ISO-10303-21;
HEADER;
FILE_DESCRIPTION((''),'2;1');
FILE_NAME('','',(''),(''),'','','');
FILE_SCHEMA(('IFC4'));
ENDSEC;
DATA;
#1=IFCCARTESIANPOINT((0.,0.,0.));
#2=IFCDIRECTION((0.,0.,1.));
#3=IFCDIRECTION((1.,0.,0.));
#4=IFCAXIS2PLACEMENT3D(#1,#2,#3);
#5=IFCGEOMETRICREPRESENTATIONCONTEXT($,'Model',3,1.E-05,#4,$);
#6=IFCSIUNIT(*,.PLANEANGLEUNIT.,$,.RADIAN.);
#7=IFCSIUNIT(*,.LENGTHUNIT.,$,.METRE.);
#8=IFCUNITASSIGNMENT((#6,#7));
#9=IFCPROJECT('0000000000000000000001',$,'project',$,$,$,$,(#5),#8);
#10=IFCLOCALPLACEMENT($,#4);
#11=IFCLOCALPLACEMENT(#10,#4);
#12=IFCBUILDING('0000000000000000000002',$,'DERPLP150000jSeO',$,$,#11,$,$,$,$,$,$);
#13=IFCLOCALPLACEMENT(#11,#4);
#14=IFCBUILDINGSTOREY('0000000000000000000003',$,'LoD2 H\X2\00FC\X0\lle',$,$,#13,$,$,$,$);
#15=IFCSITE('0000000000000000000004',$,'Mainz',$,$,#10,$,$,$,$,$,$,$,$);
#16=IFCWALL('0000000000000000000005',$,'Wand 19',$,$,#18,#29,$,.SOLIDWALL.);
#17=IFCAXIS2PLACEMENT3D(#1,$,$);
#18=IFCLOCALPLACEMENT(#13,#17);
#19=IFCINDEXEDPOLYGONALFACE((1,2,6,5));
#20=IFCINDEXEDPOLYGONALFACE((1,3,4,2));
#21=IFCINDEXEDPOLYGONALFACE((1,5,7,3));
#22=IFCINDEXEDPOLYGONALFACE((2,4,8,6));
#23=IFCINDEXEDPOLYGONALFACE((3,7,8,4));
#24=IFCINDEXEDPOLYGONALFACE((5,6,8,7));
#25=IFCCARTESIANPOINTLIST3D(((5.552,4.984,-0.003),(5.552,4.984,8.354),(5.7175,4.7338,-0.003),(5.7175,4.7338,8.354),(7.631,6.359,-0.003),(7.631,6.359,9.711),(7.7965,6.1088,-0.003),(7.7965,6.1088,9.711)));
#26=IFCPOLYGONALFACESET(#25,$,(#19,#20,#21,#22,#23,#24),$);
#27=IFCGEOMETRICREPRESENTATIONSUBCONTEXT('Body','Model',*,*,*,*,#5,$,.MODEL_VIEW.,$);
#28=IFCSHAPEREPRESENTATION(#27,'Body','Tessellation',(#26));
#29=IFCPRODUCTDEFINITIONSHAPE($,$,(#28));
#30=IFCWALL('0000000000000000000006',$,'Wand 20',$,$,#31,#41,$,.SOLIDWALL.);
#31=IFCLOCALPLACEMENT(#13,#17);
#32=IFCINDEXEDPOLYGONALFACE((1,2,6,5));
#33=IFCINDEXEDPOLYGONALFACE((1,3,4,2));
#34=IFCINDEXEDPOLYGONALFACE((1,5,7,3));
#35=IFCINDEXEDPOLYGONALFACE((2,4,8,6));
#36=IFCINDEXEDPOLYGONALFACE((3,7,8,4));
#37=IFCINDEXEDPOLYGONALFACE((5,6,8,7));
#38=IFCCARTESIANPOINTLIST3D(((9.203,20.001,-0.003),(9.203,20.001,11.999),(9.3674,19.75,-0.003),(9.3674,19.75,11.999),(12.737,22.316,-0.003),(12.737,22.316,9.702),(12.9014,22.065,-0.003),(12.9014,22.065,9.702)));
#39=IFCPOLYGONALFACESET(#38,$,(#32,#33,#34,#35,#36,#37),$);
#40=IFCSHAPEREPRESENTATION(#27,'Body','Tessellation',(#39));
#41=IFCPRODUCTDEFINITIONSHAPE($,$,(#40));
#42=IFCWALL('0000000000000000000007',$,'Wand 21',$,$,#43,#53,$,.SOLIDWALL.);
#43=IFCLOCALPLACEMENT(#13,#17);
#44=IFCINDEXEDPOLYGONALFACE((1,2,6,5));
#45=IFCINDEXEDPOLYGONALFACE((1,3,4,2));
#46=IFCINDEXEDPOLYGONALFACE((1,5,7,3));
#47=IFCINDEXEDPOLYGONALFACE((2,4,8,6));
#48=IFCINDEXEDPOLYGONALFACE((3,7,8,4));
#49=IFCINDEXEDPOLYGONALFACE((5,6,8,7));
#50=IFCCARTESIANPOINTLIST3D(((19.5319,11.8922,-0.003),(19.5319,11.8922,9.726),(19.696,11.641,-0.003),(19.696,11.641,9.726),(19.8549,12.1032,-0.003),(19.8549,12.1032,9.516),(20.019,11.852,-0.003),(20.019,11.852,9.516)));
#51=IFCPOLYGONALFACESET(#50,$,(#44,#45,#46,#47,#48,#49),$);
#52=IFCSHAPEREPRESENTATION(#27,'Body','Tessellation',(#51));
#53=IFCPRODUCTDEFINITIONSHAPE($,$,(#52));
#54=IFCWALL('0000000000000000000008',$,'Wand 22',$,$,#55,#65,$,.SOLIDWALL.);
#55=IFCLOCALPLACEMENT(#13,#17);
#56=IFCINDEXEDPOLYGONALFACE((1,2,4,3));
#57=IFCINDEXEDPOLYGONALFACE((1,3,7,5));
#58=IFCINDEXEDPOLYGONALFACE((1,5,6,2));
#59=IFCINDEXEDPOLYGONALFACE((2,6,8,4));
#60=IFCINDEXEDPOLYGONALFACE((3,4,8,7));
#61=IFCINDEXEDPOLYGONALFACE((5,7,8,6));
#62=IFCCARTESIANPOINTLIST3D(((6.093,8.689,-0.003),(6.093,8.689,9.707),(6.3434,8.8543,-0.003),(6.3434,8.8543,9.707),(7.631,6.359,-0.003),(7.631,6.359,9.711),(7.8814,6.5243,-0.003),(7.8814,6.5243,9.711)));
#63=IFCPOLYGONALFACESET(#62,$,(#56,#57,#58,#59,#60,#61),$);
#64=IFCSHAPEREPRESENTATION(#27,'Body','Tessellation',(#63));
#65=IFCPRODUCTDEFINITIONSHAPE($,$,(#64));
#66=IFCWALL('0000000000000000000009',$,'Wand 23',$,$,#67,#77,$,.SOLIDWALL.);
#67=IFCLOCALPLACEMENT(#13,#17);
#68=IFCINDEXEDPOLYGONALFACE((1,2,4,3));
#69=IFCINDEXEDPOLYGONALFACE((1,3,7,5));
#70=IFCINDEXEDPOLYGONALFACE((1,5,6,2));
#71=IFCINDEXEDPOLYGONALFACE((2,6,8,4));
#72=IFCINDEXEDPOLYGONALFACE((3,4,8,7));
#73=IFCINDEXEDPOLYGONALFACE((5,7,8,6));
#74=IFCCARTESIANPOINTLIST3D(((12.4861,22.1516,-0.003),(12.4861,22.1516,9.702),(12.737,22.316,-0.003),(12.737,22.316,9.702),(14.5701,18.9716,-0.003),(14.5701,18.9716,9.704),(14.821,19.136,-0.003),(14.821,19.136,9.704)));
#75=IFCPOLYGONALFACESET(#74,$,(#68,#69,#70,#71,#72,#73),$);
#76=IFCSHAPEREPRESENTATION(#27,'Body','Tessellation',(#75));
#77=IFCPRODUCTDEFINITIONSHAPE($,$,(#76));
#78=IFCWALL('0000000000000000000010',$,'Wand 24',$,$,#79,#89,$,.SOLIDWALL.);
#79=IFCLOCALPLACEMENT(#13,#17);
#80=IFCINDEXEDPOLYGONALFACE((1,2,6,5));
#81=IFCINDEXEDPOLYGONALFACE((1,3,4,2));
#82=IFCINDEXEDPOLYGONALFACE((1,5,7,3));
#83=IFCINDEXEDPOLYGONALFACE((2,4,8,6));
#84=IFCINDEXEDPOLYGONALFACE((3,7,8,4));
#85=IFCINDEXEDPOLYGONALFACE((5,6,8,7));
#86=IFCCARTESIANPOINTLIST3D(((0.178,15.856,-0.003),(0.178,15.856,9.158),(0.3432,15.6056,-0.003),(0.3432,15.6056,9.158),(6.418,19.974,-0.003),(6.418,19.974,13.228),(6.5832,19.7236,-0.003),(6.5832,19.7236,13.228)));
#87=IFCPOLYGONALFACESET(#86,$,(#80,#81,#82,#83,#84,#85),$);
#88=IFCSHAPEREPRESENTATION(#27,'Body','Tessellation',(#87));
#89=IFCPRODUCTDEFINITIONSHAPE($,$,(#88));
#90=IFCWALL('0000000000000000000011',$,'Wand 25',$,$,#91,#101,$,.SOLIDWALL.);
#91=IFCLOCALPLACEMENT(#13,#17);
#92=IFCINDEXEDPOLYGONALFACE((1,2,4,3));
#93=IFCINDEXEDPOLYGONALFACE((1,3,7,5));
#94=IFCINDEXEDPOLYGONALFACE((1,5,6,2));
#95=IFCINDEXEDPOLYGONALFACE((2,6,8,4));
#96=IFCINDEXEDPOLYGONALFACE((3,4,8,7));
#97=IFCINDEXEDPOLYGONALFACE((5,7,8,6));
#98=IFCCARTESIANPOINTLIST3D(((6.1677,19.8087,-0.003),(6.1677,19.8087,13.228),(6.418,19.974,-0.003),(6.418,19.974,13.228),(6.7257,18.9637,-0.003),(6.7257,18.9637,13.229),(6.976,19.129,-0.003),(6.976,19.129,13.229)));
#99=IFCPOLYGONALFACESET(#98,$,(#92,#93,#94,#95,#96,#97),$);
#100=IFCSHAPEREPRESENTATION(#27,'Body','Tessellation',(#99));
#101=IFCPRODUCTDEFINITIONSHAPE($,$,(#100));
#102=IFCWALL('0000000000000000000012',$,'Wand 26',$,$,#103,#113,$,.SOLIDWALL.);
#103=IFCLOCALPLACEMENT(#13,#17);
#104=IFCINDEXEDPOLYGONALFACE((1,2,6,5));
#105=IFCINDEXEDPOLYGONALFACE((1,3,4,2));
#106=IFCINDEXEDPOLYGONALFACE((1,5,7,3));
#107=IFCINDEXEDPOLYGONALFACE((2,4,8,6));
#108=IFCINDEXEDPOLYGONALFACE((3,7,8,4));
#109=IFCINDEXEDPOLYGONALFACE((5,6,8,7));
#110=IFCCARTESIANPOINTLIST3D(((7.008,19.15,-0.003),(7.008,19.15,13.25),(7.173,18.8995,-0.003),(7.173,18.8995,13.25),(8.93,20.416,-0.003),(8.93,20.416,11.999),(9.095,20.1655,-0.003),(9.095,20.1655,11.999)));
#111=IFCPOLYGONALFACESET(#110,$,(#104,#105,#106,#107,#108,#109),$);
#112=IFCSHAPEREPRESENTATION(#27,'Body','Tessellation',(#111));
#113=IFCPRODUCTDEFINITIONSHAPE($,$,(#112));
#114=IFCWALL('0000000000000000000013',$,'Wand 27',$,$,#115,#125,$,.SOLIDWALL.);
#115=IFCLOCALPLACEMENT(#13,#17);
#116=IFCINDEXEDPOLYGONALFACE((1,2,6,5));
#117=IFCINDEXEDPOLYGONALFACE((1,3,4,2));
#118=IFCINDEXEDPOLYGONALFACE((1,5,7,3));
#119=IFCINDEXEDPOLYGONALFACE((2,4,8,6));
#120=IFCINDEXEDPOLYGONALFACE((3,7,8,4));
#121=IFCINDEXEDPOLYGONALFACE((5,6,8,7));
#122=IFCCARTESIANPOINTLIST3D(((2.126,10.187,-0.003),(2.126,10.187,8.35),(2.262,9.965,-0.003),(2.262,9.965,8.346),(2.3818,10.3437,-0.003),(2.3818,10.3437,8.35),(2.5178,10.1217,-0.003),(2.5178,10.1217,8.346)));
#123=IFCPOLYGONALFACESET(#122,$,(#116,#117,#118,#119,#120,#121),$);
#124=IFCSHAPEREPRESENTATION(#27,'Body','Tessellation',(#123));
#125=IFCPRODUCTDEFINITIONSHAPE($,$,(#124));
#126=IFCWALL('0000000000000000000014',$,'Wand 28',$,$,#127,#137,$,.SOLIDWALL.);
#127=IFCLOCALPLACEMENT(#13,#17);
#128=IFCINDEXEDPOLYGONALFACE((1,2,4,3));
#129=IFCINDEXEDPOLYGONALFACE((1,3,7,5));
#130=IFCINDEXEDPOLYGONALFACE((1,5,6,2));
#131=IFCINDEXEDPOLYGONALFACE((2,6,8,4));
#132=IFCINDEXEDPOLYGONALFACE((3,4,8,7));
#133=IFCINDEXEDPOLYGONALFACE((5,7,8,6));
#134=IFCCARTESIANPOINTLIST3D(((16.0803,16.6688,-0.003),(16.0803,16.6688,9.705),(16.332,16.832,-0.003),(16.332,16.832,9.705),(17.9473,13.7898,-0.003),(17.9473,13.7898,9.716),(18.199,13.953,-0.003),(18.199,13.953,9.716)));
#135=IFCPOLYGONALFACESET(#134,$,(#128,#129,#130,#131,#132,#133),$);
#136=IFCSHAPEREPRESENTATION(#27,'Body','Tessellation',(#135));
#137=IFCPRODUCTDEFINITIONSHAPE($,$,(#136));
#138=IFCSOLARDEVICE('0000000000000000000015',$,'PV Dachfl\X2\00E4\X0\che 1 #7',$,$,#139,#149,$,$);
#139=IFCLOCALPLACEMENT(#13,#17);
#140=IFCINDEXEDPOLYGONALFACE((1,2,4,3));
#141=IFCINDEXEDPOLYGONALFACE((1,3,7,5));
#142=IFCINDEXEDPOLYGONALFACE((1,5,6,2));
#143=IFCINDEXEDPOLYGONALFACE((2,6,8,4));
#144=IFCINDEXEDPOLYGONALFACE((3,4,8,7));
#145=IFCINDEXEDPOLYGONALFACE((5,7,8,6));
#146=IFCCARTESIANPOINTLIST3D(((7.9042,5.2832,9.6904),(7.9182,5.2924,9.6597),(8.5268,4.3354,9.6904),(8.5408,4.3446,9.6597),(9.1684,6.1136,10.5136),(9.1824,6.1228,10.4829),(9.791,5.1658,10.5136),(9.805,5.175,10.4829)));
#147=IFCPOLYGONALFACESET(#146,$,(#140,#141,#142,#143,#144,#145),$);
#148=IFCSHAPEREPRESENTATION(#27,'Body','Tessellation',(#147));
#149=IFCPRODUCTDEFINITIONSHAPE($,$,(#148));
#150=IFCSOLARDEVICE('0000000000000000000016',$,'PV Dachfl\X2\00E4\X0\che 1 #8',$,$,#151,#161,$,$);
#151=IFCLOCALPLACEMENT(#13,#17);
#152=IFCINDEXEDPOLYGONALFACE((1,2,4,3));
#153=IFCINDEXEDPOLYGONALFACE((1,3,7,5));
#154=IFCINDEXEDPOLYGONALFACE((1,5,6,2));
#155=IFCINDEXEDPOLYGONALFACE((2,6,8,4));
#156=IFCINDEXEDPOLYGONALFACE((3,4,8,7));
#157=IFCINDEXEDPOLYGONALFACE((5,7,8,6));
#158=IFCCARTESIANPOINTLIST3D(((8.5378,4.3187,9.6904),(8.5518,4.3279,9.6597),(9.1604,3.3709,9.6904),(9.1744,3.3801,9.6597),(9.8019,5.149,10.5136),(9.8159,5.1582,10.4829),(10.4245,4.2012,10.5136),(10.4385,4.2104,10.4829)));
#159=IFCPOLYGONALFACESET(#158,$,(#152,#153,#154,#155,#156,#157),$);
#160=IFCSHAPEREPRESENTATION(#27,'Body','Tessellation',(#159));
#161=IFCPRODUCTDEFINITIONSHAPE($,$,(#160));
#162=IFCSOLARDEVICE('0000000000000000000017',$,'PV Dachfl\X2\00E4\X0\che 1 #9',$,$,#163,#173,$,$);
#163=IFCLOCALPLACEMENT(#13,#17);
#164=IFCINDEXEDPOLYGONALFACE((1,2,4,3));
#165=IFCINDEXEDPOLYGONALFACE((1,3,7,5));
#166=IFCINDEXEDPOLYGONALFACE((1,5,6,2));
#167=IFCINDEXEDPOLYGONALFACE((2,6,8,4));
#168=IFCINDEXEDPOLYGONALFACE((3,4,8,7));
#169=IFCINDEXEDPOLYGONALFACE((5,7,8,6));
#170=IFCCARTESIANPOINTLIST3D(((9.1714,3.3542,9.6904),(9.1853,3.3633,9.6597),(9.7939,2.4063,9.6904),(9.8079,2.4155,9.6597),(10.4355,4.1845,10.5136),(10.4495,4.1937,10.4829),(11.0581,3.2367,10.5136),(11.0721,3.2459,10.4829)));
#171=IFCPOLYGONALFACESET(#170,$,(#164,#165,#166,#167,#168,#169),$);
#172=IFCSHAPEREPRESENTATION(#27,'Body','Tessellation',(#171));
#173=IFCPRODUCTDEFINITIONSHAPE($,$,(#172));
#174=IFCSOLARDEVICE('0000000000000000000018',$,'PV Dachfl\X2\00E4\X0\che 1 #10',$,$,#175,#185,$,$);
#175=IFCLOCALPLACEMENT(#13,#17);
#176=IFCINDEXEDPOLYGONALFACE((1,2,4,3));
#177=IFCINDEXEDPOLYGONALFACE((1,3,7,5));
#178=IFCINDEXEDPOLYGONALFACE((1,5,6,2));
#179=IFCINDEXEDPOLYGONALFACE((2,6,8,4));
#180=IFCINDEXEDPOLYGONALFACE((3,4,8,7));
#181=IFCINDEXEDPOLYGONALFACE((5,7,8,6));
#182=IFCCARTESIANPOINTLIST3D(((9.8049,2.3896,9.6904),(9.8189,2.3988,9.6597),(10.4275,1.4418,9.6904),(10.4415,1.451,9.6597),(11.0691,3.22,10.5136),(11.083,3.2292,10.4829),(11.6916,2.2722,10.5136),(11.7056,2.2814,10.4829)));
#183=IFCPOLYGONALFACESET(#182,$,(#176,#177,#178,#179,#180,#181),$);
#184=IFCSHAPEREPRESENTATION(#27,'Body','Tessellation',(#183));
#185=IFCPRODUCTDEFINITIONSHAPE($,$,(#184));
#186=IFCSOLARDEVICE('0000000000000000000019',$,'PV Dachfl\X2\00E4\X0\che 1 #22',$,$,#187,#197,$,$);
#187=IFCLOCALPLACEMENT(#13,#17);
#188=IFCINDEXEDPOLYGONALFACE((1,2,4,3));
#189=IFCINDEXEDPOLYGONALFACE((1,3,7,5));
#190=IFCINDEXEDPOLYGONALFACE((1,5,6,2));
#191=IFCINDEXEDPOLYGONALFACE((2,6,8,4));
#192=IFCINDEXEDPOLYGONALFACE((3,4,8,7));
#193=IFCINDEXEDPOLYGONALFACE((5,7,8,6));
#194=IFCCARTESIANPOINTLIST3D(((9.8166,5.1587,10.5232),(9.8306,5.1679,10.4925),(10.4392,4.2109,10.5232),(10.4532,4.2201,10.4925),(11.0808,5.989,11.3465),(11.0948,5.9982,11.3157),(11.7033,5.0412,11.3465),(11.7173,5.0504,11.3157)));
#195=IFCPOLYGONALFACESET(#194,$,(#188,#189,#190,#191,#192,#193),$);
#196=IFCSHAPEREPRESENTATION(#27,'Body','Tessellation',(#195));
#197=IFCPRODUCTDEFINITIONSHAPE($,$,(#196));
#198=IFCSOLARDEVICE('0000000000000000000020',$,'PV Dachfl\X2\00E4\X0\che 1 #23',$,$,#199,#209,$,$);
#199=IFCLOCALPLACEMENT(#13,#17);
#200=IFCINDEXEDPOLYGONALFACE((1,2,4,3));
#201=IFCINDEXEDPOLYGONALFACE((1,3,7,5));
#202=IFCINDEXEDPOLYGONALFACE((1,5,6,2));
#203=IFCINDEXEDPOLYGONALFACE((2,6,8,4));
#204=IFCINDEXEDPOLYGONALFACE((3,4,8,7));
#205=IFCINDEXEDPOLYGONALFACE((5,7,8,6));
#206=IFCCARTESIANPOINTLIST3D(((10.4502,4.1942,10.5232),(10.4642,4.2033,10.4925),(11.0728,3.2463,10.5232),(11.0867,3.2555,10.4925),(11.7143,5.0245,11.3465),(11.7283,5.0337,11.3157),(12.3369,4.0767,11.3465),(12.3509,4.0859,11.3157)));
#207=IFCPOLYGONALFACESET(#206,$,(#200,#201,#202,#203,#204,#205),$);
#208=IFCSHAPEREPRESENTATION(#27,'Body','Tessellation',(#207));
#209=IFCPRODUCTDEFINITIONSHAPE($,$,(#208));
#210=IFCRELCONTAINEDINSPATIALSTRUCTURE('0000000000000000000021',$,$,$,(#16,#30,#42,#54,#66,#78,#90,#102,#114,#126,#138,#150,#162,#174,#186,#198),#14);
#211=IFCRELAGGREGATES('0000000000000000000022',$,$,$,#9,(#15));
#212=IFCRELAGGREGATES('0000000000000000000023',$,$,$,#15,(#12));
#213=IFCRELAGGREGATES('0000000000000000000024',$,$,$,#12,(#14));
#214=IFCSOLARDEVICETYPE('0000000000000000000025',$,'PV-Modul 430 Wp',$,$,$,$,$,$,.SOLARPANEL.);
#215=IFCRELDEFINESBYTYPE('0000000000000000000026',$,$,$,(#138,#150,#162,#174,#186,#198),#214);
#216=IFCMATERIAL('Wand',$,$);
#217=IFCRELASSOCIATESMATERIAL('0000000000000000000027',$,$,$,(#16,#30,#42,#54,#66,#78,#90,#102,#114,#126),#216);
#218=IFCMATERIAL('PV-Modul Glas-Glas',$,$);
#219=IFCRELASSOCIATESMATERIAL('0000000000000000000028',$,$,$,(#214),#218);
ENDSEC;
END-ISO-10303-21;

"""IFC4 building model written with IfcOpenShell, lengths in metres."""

from ifc_helpers import new_model, si_unit, frame, frame_2d, origin, origin_with_axes, place, context, subcontext, project, spatial, polyline, rectangle, outline, extrude, source, transform, mapped, material, type_object, type_shapes, element, save


model = new_model("IFC4")

# Units and contexts
model_context = context("Model", 3, precision=1e-05, world=origin_with_axes())
body_context = subcontext(model_context, "Body", "Model", "MODEL_VIEW")
ifc_project = project(units=[si_unit("PLANEANGLEUNIT", "RADIAN"), si_unit("LENGTHUNIT", "METRE")], contexts=[model_context])

# Site, building, storey
site_placement = place(None, origin_with_axes())
site = spatial("IfcSite", under=ifc_project, at=site_placement, Name="Mainz")
building_placement = place(site_placement, origin_with_axes())
building = spatial("IfcBuilding", under=site, at=building_placement, Name="DERPLP150000jSeO")
storey_placement = place(building_placement, origin_with_axes())
storey = spatial("IfcBuildingStorey", under=building, at=storey_placement, Name="LoD2 Hülle")

# Walls
ifc_material_1 = material(Name="Wand")
wall_1_placement = place(storey_placement, origin_with_axes())
element("IfcWall", 1, at=wall_1_placement, inside=storey, material=ifc_material_1, Name="Wand 19", PredefinedType="SOLIDWALL", context=body_context, shape_type="SweptSolid", body=[
    extrude(outline(polyline([(0.0, 0.0), (2.838, 0.0), (-1.8068, 8.5316), (-3.9959, 7.3398), (0.0, 0.0)])), frame((5.552, 4.984, 8.354), z_axis=(-0.551641, 0.834082, 0.0), x_axis=(0.732555, 0.484494, 0.478152)), (0.0, 0.0, -1.0), 0.3),
])
wall_2_placement = place(storey_placement, origin_with_axes())
element("IfcWall", 2, at=wall_2_placement, inside=storey, material=ifc_material_1, Name="Wand 20", PredefinedType="SOLIDWALL", context=body_context, shape_type="SweptSolid", body=[
    extrude(outline(polyline([(0.0, 0.0), (4.8088, 0.0), (9.4445, 8.5262), (5.7329, 10.5443), (0.0, 0.0)])), frame((9.203, 20.001, 11.999), z_axis=(-0.547963, 0.836502, 0.0), x_axis=(0.734902, 0.481409, -0.477666)), (0.0, 0.0, -1.0), 0.3),
])
wall_3_placement = place(storey_placement, origin_with_axes())
element("IfcWall", 3, at=wall_3_placement, inside=storey, material=ifc_material_1, Name="Wand 21", PredefinedType="SOLIDWALL", context=body_context, shape_type="SweptSolid", body=[
    extrude(outline(polyline([(0.0, 0.0), (0.4393, 0.0), (-4.2119, 8.5452), (-4.5508, 8.3607), (0.0, 0.0)])), frame((20.019, 11.852, 9.516), z_axis=(0.5469, -0.837198, 0.0), x_axis=(-0.735326, -0.480353, 0.478076)), (0.0, 0.0, -1.0), 0.3),
])
wall_4_placement = place(storey_placement, origin_with_axes())
element("IfcWall", 4, at=wall_4_placement, inside=storey, material=ifc_material_1, Name="Wand 22", PredefinedType="SOLIDWALL", context=body_context, shape_type="SweptSolid", body=[
    extrude(outline(polyline([(0.0, 0.0), (2.7918, 0.0), (2.8058, 9.71), (0.0139, 9.714), (0.0, 0.0)])), frame((7.631, 6.359, 9.711), z_axis=(-0.834576, -0.550892, 0.0), x_axis=(-0.550892, 0.834576, -0.001433)), (0.0, 0.0, -1.0), 0.3),
])
wall_5_placement = place(storey_placement, origin_with_axes())
element("IfcWall", 5, at=wall_5_placement, inside=storey, material=ifc_material_1, Name="Wand 23", PredefinedType="SOLIDWALL", context=body_context, shape_type="SweptSolid", body=[
    extrude(outline(polyline([(0.0, 0.0), (3.802, 0.0), (3.7969, 9.707), (-0.0051, 9.705), (0.0, 0.0)])), frame((12.737, 22.316, 9.702), z_axis=(0.836395, 0.548128, 0.0), x_axis=(0.548128, -0.836394, 0.000526)), (0.0, 0.0, -1.0), 0.3),
])
wall_6_placement = place(storey_placement, origin_with_axes())
element("IfcWall", 6, at=wall_6_placement, inside=storey, material=ifc_material_1, Name="Wand 24", PredefinedType="SOLIDWALL", context=body_context, shape_type="SweptSolid", body=[
    extrude(outline(polyline([(0.0, 0.0), (8.5124, 0.0), (2.1863, 11.6207), (-4.3801, 8.046), (0.0, 0.0)])), frame((0.178, 15.856, 9.158), z_axis=(-0.550805, 0.834634, 0.0), x_axis=(0.733051, 0.483767, 0.478128)), (0.0, 0.0, -1.0), 0.3),
])
wall_7_placement = place(storey_placement, origin_with_axes())
element("IfcWall", 7, at=wall_7_placement, inside=storey, material=ifc_material_1, Name="Wand 25", PredefinedType="SOLIDWALL", context=body_context, shape_type="SweptSolid", body=[
    extrude(outline(polyline([(0.0, 0.0), (1.0126, 0.0), (0.9995, 13.232), (-0.0131, 13.231), (0.0, 0.0)])), frame((6.418, 19.974, 13.228), z_axis=(0.834473, 0.551049, 0.0), x_axis=(0.551048, -0.834473, 0.000988)), (0.0, 0.0, -1.0), 0.3),
])
wall_8_placement = place(storey_placement, origin_with_axes())
element("IfcWall", 8, at=wall_8_placement, inside=storey, material=ifc_material_1, Name="Wand 26", PredefinedType="SOLIDWALL", context=body_context, shape_type="SweptSolid", body=[
    extrude(outline(polyline([(0.0, 0.0), (2.6195, 0.0), (8.3513, 10.5449), (6.3292, 11.644), (0.0, 0.0)])), frame((7.008, 19.15, 13.25), z_axis=(-0.550079, 0.835112, 0.0), x_axis=(0.733725, 0.483296, -0.47757)), (0.0, 0.0, -1.0), 0.3),
])
wall_9_placement = place(storey_placement, origin_with_axes())
element("IfcWall", 9, at=wall_9_placement, inside=storey, material=ifc_material_1, Name="Wand 27", PredefinedType="SOLIDWALL", context=body_context, shape_type="SweptSolid", body=[
    extrude(outline(polyline([(0.0, 0.0), (0.2604, 0.0), (0.1321, 8.352), (-0.1283, 8.348), (0.0, 0.0)])), frame((2.262, 9.965, 8.346), z_axis=(-0.852712, -0.522382, 0.0), x_axis=(-0.52232, 0.852611, 0.015362)), (0.0, 0.0, -1.0), 0.3),
])
wall_10_placement = place(storey_placement, origin_with_axes())
element("IfcWall", 10, at=wall_10_placement, inside=storey, material=ifc_material_1, Name="Wand 28", PredefinedType="SOLIDWALL", context=body_context, shape_type="SweptSolid", body=[
    extrude(outline(polyline([(0.0, 0.0), (3.4314, 0.0), (3.4002, 9.719), (-0.0311, 9.708), (0.0, 0.0)])), frame((16.332, 16.832, 9.705), z_axis=(0.839022, 0.544097, 0.0), x_axis=(0.544094, -0.839018, 0.003206)), (0.0, 0.0, -1.0), 0.3),
])

# Solar devices
ifc_material_2 = material(Name="PV-Modul Glas-Glas")
solar_device_type = type_object("IfcSolarDeviceType", Name="PV-Modul 430 Wp", PredefinedType="SOLARPANEL", material=ifc_material_2)
shared_shape = source(origin_with_axes(), body_context, "Body", "SweptSolid", [
    extrude(rectangle(XDim=1.722, YDim=1.134, at=frame_2d((0.861, 0.567))), origin(), (0.0, 0.0, 1.0), 0.035),
])
type_shapes(solar_device_type, [shared_shape])
for number, where, z_axis, x_axis, name in (
    (11, (8.5408, 4.3446, 9.6597), (-0.399585, -0.262469, 0.878318), (0.734113, 0.482204, 0.478077), "PV Dachfläche 1 #7"),
    (12, (9.1744, 3.3801, 9.6597), (-0.399585, -0.262469, 0.878318), (0.734113, 0.482204, 0.478077), "PV Dachfläche 1 #8"),
    (13, (9.8079, 2.4155, 9.6597), (-0.399585, -0.262469, 0.878318), (0.734113, 0.482204, 0.478077), "PV Dachfläche 1 #9"),
    (14, (10.4415, 1.451, 9.6597), (-0.399585, -0.262469, 0.878318), (0.734113, 0.482204, 0.478077), "PV Dachfläche 1 #10"),
    (15, (10.4532, 4.2201, 10.4925), (-0.399585, -0.262469, 0.878318), (0.734113, 0.482204, 0.478077), "PV Dachfläche 1 #22"),
    (16, (11.0867, 3.2555, 10.4925), (-0.399585, -0.262469, 0.878318), (0.734113, 0.482204, 0.478077), "PV Dachfläche 1 #23"),
):
    element("IfcSolarDevice", number, at=place(storey_placement, frame(where, z_axis=z_axis, x_axis=x_axis)), inside=storey, type_object=solar_device_type, Name=name, context=body_context, shape_type="MappedRepresentation", body=[
        mapped(shared_shape, transform((0.0, 0.0, 0.0), x_axis=(1.0, 0.0, 0.0), y_axis=(0.0, 1.0, 0.0), z_axis=(0.0, 0.0, 1.0), scale=1.0)),
    ])

save(model, "model.ifc")
